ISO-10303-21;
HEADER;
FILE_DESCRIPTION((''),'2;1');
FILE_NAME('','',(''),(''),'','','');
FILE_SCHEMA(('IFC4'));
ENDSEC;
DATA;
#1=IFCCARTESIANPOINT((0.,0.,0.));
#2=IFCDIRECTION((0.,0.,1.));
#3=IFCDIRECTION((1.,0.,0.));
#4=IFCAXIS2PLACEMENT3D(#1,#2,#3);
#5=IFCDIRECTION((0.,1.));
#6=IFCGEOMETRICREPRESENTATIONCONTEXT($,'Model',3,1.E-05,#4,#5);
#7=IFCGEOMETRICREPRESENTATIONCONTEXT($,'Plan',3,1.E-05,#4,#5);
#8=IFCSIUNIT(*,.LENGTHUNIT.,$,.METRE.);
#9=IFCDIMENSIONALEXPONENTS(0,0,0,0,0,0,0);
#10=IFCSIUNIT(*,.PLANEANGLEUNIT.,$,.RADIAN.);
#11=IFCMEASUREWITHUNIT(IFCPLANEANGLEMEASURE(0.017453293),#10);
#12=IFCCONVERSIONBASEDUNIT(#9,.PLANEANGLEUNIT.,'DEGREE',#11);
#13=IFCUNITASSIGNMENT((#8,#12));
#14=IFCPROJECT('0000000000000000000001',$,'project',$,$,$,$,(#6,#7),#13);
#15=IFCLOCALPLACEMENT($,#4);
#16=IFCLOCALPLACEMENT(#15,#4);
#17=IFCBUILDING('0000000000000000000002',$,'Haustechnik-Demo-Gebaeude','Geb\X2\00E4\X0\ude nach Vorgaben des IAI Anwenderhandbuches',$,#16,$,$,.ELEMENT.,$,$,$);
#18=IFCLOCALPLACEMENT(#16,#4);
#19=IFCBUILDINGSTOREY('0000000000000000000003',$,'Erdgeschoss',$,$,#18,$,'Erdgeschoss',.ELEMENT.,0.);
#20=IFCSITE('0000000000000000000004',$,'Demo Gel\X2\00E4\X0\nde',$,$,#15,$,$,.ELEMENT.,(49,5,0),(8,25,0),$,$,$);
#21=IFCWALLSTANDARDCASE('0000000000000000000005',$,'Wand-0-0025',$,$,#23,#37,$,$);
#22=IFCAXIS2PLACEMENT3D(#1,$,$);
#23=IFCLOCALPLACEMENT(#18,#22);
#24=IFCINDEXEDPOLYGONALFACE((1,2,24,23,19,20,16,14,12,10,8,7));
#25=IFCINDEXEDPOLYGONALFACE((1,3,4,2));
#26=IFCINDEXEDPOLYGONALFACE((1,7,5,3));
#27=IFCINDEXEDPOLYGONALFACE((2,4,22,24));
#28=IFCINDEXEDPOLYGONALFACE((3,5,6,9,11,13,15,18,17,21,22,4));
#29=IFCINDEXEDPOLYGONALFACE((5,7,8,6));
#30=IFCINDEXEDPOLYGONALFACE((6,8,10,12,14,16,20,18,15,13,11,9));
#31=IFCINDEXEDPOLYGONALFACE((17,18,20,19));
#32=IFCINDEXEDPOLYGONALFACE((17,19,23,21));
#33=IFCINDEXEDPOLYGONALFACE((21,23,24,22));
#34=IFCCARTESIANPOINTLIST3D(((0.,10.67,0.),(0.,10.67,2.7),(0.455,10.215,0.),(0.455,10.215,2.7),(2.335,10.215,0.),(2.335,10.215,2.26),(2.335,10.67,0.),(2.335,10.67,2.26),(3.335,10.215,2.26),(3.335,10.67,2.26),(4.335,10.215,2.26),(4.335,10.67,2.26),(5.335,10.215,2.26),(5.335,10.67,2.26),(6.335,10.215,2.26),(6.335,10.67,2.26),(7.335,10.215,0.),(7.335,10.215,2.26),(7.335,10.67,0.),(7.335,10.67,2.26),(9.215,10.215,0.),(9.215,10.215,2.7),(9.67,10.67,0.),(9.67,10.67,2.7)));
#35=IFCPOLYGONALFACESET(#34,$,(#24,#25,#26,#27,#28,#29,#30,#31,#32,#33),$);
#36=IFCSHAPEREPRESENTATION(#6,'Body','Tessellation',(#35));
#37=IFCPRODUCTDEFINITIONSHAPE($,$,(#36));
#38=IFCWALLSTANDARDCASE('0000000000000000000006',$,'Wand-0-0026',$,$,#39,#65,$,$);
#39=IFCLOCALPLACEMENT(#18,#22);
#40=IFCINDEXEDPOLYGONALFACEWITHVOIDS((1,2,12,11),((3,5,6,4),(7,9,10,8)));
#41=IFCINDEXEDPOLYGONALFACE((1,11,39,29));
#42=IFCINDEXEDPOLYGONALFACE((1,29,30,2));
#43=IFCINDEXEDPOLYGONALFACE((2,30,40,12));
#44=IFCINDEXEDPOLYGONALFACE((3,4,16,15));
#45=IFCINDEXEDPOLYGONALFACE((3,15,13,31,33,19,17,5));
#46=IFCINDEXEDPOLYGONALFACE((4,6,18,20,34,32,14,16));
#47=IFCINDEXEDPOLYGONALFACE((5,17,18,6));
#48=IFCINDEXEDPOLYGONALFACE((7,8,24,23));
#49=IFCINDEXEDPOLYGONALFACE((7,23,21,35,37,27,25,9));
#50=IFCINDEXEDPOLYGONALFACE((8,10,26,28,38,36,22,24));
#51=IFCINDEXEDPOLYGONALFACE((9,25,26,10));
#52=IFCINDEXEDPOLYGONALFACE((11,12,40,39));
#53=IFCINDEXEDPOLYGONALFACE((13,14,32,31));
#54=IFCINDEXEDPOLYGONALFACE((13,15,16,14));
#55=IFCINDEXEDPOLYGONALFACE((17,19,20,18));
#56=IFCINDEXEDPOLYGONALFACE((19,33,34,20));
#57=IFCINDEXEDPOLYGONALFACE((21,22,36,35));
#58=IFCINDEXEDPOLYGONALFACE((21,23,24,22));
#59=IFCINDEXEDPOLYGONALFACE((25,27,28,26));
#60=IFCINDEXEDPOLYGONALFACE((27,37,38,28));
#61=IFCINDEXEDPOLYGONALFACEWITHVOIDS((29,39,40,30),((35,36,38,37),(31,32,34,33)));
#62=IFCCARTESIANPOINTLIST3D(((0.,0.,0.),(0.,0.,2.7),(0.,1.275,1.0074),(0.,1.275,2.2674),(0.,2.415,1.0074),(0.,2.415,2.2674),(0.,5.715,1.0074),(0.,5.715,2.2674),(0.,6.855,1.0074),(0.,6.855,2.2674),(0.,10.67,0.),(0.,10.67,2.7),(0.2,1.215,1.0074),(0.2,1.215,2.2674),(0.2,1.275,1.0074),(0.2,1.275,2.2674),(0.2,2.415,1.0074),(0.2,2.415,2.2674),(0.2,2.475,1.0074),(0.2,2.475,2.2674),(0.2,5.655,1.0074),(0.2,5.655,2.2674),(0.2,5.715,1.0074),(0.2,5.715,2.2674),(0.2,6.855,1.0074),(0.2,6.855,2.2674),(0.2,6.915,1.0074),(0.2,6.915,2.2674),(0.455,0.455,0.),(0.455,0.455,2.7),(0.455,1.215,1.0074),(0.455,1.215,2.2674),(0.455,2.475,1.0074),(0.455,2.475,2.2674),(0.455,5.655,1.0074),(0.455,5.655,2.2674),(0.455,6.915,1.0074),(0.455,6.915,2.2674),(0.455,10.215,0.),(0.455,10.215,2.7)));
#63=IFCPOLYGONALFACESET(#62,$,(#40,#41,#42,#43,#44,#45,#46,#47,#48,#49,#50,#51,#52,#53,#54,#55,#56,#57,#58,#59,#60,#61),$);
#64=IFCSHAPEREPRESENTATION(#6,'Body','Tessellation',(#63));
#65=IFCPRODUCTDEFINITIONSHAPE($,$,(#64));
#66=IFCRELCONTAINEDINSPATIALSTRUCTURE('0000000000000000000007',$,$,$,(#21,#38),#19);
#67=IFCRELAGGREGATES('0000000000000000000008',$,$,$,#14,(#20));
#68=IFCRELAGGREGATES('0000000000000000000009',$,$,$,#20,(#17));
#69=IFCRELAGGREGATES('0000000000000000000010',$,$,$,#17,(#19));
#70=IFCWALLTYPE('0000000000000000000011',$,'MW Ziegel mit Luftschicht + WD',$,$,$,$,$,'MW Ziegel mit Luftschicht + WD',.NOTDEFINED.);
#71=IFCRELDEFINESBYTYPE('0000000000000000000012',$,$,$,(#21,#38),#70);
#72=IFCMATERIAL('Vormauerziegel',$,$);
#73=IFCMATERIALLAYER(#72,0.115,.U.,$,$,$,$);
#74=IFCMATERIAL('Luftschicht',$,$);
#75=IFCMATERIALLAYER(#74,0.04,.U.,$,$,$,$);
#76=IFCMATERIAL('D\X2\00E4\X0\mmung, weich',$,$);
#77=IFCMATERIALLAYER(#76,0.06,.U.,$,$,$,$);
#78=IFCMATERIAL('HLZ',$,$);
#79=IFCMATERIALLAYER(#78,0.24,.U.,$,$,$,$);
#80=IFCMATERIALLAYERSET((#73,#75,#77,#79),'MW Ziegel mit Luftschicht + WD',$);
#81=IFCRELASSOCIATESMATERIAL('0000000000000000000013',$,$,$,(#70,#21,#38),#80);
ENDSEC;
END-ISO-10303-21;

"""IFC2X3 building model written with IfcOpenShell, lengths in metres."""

from ifc_helpers import new_model, entity, si_unit, converted_unit, direction, frame, origin_with_axes, place, context, project, spatial, polyline, outline, extrude, material, layer, layer_set, layer_usage, type_object, element, save


model = new_model("IFC2X3")

# Units and contexts
model_context = context("Model", 3, precision=1e-05, world=origin_with_axes(), true_north=direction((0.0, 1.0)))
plan_context = context("Plan", 3, precision=1e-05, world=origin_with_axes(), true_north=direction((0.0, 1.0)))
ifc_project = project(units=[si_unit("LENGTHUNIT", "METRE"), converted_unit("PLANEANGLEUNIT", "DEGREE", entity("IfcPlaneAngleMeasure", 0.017453293), si_unit("PLANEANGLEUNIT", "RADIAN"), dimensions=[0, 0, 0, 0, 0, 0, 0])], contexts=[model_context, plan_context])

# Site, building, storey
site_placement = place(None, origin_with_axes())
site = spatial("IfcSite", under=ifc_project, at=site_placement, Name="Demo Gelände", CompositionType="ELEMENT", RefLatitude=(49, 5, 0), RefLongitude=(8, 25, 0))
building_placement = place(site_placement, origin_with_axes())
building = spatial("IfcBuilding", under=site, at=building_placement, Name="Haustechnik-Demo-Gebaeude", Description="Gebäude nach Vorgaben des IAI Anwenderhandbuches", CompositionType="ELEMENT")
storey_placement = place(building_placement, origin_with_axes())
storey = spatial("IfcBuildingStorey", under=building, at=storey_placement, Name="Erdgeschoss", LongName="Erdgeschoss", CompositionType="ELEMENT", Elevation=0.0)

# Walls, openings
ifc_material_1 = material(Name="Vormauerziegel")
ifc_layer_1 = layer(ifc_material_1, 0.115, ventilated="UNKNOWN")
ifc_material_2 = material(Name="Luftschicht")
ifc_layer_2 = layer(ifc_material_2, 0.04, ventilated="UNKNOWN")
ifc_material_3 = material(Name="Dämmung, weich")
ifc_layer_3 = layer(ifc_material_3, 0.06, ventilated="UNKNOWN")
ifc_material_4 = material(Name="HLZ")
ifc_layer_4 = layer(ifc_material_4, 0.24, ventilated="UNKNOWN")
ifc_layer_set_1 = layer_set([ifc_layer_1, ifc_layer_2, ifc_layer_3, ifc_layer_4], Name="MW Ziegel mit Luftschicht + WD")
wall_type_1 = type_object("IfcWallType", Name="MW Ziegel mit Luftschicht + WD", ElementType="MW Ziegel mit Luftschicht + WD", PredefinedType="NOTDEFINED", material=ifc_layer_set_1)
ifc_layer_usage_1 = layer_usage(ifc_layer_set_1, "AXIS2", "NEGATIVE", 0.0)
wall_1_placement = place(storey_placement, frame((0.0, 10.67, 0.0), z_axis=(0.0, 0.0, 1.0), x_axis=(1.0, 0.0, 0.0)))
wall_1 = element("IfcWallStandardCase", 1, at=wall_1_placement, inside=storey, type_object=wall_type_1, material=ifc_layer_usage_1, Name="Wand-0-0025", context=model_context, shape_type="SweptSolid", body=[
    extrude(outline(polyline([(0.455, -0.455), (9.215, -0.455), (9.67, 0.0), (0.0, 0.0), (0.455, -0.455)])), origin_with_axes(), (0.0, 0.0, 1.0), 2.7),
])
opening_1_placement = place(wall_1_placement, frame((4.835, -0.455, 0.0), z_axis=(0.0, 0.0, 1.0), x_axis=(1.0, 0.0, 0.0)))
element("IfcOpeningElement", 2, at=opening_1_placement, cuts=wall_1, ObjectType="Opening", context=model_context, shape_type="SweptSolid", body=[
    extrude(outline(polyline([(-0.5, 0.0), (0.5, 0.0), (0.5, 2.26), (-0.5, 2.26), (-0.5, 0.0)])), frame((0.0, 0.0, 0.0), z_axis=(0.0, 1.0, 0.0), x_axis=(-1.0, 0.0, 0.0)), (0.0, 0.0, 1.0), 0.455),
])
opening_2_placement = place(wall_1_placement, frame((6.835, -0.455, 0.0), z_axis=(0.0, 0.0, 1.0), x_axis=(1.0, 0.0, 0.0)))
element("IfcOpeningElement", 3, at=opening_2_placement, cuts=wall_1, ObjectType="Opening", context=model_context, shape_type="SweptSolid", body=[
    extrude(outline(polyline([(-0.5, 0.0), (0.5, 0.0), (0.5, 2.26), (-0.5, 2.26), (-0.5, 0.0)])), frame((0.0, 0.0, 0.0), z_axis=(0.0, 1.0, 0.0), x_axis=(-1.0, 0.0, 0.0)), (0.0, 0.0, 1.0), 0.455),
])
opening_3_placement = place(wall_1_placement, frame((2.835, -0.455, 0.0), z_axis=(0.0, 0.0, 1.0), x_axis=(1.0, 0.0, 0.0)))
element("IfcOpeningElement", 4, at=opening_3_placement, cuts=wall_1, ObjectType="Opening", context=model_context, shape_type="SweptSolid", body=[
    extrude(outline(polyline([(-0.5, 0.0), (0.5, 0.0), (0.5, 2.26), (-0.5, 2.26), (-0.5, 0.0)])), frame((0.0, 0.0, 0.0), z_axis=(0.0, 1.0, 0.0), x_axis=(-1.0, 0.0, 0.0)), (0.0, 0.0, 1.0), 0.455),
])
opening_4_placement = place(wall_1_placement, frame((3.835, -0.455, 0.0), z_axis=(0.0, 0.0, 1.0), x_axis=(1.0, 0.0, 0.0)))
element("IfcOpeningElement", 5, at=opening_4_placement, cuts=wall_1, ObjectType="Opening", context=model_context, shape_type="SweptSolid", body=[
    extrude(outline(polyline([(-0.5, 0.0), (0.5, 0.0), (0.5, 2.26), (-0.5, 2.26), (-0.5, 0.0)])), frame((0.0, 0.0, 0.0), z_axis=(0.0, 1.0, 0.0), x_axis=(-1.0, 0.0, 0.0)), (0.0, 0.0, 1.0), 0.455),
])
opening_5_placement = place(wall_1_placement, frame((5.835, -0.455, 0.0), z_axis=(0.0, 0.0, 1.0), x_axis=(1.0, 0.0, 0.0)))
element("IfcOpeningElement", 6, at=opening_5_placement, cuts=wall_1, ObjectType="Opening", context=model_context, shape_type="SweptSolid", body=[
    extrude(outline(polyline([(-0.5, 0.0), (0.5, 0.0), (0.5, 2.26), (-0.5, 2.26), (-0.5, 0.0)])), frame((0.0, 0.0, 0.0), z_axis=(0.0, 1.0, 0.0), x_axis=(-1.0, 0.0, 0.0)), (0.0, 0.0, 1.0), 0.455),
])
ifc_layer_usage_2 = layer_usage(ifc_layer_set_1, "AXIS2", "POSITIVE", 0.0)
wall_2_placement = place(storey_placement, frame((0.0, 10.67, 0.0), z_axis=(0.0, 0.0, 1.0), x_axis=(0.0, -1.0, 0.0)))
wall_2 = element("IfcWallStandardCase", 7, at=wall_2_placement, inside=storey, type_object=wall_type_1, material=ifc_layer_usage_2, Name="Wand-0-0026", context=model_context, shape_type="SweptSolid", body=[
    extrude(outline(polyline([(0.0, 0.0), (10.67, 0.0), (10.215, 0.455), (0.455, 0.455), (0.0, 0.0)])), origin_with_axes(), (0.0, 0.0, 1.0), 2.7),
])
opening_6_placement = place(wall_2_placement, frame((4.385, 0.0, 1.0074), z_axis=(0.0, 0.0, 1.0), x_axis=(1.0, 0.0, 0.0)))
element("IfcOpeningElement", 8, at=opening_6_placement, cuts=wall_2, ObjectType="Opening", context=model_context, shape_type="SweptSolid", body=[
    extrude(outline(polyline([(-0.57, 0.0), (0.57, 0.0), (0.57, 0.2), (0.63, 0.2), (0.63, 0.455), (-0.63, 0.455), (-0.63, 0.2), (-0.57, 0.2), (-0.57, 0.0)])), origin_with_axes(), (0.0, 0.0, 1.0), 1.26),
])
opening_7_placement = place(wall_2_placement, frame((8.825, 0.0, 1.0074), z_axis=(0.0, 0.0, 1.0), x_axis=(1.0, 0.0, 0.0)))
element("IfcOpeningElement", 9, at=opening_7_placement, cuts=wall_2, ObjectType="Opening", context=model_context, shape_type="SweptSolid", body=[
    extrude(outline(polyline([(-0.57, 0.0), (0.57, 0.0), (0.57, 0.2), (0.63, 0.2), (0.63, 0.455), (-0.63, 0.455), (-0.63, 0.2), (-0.57, 0.2), (-0.57, 0.0)])), origin_with_axes(), (0.0, 0.0, 1.0), 1.26),
])

save(model, "model.ifc")
